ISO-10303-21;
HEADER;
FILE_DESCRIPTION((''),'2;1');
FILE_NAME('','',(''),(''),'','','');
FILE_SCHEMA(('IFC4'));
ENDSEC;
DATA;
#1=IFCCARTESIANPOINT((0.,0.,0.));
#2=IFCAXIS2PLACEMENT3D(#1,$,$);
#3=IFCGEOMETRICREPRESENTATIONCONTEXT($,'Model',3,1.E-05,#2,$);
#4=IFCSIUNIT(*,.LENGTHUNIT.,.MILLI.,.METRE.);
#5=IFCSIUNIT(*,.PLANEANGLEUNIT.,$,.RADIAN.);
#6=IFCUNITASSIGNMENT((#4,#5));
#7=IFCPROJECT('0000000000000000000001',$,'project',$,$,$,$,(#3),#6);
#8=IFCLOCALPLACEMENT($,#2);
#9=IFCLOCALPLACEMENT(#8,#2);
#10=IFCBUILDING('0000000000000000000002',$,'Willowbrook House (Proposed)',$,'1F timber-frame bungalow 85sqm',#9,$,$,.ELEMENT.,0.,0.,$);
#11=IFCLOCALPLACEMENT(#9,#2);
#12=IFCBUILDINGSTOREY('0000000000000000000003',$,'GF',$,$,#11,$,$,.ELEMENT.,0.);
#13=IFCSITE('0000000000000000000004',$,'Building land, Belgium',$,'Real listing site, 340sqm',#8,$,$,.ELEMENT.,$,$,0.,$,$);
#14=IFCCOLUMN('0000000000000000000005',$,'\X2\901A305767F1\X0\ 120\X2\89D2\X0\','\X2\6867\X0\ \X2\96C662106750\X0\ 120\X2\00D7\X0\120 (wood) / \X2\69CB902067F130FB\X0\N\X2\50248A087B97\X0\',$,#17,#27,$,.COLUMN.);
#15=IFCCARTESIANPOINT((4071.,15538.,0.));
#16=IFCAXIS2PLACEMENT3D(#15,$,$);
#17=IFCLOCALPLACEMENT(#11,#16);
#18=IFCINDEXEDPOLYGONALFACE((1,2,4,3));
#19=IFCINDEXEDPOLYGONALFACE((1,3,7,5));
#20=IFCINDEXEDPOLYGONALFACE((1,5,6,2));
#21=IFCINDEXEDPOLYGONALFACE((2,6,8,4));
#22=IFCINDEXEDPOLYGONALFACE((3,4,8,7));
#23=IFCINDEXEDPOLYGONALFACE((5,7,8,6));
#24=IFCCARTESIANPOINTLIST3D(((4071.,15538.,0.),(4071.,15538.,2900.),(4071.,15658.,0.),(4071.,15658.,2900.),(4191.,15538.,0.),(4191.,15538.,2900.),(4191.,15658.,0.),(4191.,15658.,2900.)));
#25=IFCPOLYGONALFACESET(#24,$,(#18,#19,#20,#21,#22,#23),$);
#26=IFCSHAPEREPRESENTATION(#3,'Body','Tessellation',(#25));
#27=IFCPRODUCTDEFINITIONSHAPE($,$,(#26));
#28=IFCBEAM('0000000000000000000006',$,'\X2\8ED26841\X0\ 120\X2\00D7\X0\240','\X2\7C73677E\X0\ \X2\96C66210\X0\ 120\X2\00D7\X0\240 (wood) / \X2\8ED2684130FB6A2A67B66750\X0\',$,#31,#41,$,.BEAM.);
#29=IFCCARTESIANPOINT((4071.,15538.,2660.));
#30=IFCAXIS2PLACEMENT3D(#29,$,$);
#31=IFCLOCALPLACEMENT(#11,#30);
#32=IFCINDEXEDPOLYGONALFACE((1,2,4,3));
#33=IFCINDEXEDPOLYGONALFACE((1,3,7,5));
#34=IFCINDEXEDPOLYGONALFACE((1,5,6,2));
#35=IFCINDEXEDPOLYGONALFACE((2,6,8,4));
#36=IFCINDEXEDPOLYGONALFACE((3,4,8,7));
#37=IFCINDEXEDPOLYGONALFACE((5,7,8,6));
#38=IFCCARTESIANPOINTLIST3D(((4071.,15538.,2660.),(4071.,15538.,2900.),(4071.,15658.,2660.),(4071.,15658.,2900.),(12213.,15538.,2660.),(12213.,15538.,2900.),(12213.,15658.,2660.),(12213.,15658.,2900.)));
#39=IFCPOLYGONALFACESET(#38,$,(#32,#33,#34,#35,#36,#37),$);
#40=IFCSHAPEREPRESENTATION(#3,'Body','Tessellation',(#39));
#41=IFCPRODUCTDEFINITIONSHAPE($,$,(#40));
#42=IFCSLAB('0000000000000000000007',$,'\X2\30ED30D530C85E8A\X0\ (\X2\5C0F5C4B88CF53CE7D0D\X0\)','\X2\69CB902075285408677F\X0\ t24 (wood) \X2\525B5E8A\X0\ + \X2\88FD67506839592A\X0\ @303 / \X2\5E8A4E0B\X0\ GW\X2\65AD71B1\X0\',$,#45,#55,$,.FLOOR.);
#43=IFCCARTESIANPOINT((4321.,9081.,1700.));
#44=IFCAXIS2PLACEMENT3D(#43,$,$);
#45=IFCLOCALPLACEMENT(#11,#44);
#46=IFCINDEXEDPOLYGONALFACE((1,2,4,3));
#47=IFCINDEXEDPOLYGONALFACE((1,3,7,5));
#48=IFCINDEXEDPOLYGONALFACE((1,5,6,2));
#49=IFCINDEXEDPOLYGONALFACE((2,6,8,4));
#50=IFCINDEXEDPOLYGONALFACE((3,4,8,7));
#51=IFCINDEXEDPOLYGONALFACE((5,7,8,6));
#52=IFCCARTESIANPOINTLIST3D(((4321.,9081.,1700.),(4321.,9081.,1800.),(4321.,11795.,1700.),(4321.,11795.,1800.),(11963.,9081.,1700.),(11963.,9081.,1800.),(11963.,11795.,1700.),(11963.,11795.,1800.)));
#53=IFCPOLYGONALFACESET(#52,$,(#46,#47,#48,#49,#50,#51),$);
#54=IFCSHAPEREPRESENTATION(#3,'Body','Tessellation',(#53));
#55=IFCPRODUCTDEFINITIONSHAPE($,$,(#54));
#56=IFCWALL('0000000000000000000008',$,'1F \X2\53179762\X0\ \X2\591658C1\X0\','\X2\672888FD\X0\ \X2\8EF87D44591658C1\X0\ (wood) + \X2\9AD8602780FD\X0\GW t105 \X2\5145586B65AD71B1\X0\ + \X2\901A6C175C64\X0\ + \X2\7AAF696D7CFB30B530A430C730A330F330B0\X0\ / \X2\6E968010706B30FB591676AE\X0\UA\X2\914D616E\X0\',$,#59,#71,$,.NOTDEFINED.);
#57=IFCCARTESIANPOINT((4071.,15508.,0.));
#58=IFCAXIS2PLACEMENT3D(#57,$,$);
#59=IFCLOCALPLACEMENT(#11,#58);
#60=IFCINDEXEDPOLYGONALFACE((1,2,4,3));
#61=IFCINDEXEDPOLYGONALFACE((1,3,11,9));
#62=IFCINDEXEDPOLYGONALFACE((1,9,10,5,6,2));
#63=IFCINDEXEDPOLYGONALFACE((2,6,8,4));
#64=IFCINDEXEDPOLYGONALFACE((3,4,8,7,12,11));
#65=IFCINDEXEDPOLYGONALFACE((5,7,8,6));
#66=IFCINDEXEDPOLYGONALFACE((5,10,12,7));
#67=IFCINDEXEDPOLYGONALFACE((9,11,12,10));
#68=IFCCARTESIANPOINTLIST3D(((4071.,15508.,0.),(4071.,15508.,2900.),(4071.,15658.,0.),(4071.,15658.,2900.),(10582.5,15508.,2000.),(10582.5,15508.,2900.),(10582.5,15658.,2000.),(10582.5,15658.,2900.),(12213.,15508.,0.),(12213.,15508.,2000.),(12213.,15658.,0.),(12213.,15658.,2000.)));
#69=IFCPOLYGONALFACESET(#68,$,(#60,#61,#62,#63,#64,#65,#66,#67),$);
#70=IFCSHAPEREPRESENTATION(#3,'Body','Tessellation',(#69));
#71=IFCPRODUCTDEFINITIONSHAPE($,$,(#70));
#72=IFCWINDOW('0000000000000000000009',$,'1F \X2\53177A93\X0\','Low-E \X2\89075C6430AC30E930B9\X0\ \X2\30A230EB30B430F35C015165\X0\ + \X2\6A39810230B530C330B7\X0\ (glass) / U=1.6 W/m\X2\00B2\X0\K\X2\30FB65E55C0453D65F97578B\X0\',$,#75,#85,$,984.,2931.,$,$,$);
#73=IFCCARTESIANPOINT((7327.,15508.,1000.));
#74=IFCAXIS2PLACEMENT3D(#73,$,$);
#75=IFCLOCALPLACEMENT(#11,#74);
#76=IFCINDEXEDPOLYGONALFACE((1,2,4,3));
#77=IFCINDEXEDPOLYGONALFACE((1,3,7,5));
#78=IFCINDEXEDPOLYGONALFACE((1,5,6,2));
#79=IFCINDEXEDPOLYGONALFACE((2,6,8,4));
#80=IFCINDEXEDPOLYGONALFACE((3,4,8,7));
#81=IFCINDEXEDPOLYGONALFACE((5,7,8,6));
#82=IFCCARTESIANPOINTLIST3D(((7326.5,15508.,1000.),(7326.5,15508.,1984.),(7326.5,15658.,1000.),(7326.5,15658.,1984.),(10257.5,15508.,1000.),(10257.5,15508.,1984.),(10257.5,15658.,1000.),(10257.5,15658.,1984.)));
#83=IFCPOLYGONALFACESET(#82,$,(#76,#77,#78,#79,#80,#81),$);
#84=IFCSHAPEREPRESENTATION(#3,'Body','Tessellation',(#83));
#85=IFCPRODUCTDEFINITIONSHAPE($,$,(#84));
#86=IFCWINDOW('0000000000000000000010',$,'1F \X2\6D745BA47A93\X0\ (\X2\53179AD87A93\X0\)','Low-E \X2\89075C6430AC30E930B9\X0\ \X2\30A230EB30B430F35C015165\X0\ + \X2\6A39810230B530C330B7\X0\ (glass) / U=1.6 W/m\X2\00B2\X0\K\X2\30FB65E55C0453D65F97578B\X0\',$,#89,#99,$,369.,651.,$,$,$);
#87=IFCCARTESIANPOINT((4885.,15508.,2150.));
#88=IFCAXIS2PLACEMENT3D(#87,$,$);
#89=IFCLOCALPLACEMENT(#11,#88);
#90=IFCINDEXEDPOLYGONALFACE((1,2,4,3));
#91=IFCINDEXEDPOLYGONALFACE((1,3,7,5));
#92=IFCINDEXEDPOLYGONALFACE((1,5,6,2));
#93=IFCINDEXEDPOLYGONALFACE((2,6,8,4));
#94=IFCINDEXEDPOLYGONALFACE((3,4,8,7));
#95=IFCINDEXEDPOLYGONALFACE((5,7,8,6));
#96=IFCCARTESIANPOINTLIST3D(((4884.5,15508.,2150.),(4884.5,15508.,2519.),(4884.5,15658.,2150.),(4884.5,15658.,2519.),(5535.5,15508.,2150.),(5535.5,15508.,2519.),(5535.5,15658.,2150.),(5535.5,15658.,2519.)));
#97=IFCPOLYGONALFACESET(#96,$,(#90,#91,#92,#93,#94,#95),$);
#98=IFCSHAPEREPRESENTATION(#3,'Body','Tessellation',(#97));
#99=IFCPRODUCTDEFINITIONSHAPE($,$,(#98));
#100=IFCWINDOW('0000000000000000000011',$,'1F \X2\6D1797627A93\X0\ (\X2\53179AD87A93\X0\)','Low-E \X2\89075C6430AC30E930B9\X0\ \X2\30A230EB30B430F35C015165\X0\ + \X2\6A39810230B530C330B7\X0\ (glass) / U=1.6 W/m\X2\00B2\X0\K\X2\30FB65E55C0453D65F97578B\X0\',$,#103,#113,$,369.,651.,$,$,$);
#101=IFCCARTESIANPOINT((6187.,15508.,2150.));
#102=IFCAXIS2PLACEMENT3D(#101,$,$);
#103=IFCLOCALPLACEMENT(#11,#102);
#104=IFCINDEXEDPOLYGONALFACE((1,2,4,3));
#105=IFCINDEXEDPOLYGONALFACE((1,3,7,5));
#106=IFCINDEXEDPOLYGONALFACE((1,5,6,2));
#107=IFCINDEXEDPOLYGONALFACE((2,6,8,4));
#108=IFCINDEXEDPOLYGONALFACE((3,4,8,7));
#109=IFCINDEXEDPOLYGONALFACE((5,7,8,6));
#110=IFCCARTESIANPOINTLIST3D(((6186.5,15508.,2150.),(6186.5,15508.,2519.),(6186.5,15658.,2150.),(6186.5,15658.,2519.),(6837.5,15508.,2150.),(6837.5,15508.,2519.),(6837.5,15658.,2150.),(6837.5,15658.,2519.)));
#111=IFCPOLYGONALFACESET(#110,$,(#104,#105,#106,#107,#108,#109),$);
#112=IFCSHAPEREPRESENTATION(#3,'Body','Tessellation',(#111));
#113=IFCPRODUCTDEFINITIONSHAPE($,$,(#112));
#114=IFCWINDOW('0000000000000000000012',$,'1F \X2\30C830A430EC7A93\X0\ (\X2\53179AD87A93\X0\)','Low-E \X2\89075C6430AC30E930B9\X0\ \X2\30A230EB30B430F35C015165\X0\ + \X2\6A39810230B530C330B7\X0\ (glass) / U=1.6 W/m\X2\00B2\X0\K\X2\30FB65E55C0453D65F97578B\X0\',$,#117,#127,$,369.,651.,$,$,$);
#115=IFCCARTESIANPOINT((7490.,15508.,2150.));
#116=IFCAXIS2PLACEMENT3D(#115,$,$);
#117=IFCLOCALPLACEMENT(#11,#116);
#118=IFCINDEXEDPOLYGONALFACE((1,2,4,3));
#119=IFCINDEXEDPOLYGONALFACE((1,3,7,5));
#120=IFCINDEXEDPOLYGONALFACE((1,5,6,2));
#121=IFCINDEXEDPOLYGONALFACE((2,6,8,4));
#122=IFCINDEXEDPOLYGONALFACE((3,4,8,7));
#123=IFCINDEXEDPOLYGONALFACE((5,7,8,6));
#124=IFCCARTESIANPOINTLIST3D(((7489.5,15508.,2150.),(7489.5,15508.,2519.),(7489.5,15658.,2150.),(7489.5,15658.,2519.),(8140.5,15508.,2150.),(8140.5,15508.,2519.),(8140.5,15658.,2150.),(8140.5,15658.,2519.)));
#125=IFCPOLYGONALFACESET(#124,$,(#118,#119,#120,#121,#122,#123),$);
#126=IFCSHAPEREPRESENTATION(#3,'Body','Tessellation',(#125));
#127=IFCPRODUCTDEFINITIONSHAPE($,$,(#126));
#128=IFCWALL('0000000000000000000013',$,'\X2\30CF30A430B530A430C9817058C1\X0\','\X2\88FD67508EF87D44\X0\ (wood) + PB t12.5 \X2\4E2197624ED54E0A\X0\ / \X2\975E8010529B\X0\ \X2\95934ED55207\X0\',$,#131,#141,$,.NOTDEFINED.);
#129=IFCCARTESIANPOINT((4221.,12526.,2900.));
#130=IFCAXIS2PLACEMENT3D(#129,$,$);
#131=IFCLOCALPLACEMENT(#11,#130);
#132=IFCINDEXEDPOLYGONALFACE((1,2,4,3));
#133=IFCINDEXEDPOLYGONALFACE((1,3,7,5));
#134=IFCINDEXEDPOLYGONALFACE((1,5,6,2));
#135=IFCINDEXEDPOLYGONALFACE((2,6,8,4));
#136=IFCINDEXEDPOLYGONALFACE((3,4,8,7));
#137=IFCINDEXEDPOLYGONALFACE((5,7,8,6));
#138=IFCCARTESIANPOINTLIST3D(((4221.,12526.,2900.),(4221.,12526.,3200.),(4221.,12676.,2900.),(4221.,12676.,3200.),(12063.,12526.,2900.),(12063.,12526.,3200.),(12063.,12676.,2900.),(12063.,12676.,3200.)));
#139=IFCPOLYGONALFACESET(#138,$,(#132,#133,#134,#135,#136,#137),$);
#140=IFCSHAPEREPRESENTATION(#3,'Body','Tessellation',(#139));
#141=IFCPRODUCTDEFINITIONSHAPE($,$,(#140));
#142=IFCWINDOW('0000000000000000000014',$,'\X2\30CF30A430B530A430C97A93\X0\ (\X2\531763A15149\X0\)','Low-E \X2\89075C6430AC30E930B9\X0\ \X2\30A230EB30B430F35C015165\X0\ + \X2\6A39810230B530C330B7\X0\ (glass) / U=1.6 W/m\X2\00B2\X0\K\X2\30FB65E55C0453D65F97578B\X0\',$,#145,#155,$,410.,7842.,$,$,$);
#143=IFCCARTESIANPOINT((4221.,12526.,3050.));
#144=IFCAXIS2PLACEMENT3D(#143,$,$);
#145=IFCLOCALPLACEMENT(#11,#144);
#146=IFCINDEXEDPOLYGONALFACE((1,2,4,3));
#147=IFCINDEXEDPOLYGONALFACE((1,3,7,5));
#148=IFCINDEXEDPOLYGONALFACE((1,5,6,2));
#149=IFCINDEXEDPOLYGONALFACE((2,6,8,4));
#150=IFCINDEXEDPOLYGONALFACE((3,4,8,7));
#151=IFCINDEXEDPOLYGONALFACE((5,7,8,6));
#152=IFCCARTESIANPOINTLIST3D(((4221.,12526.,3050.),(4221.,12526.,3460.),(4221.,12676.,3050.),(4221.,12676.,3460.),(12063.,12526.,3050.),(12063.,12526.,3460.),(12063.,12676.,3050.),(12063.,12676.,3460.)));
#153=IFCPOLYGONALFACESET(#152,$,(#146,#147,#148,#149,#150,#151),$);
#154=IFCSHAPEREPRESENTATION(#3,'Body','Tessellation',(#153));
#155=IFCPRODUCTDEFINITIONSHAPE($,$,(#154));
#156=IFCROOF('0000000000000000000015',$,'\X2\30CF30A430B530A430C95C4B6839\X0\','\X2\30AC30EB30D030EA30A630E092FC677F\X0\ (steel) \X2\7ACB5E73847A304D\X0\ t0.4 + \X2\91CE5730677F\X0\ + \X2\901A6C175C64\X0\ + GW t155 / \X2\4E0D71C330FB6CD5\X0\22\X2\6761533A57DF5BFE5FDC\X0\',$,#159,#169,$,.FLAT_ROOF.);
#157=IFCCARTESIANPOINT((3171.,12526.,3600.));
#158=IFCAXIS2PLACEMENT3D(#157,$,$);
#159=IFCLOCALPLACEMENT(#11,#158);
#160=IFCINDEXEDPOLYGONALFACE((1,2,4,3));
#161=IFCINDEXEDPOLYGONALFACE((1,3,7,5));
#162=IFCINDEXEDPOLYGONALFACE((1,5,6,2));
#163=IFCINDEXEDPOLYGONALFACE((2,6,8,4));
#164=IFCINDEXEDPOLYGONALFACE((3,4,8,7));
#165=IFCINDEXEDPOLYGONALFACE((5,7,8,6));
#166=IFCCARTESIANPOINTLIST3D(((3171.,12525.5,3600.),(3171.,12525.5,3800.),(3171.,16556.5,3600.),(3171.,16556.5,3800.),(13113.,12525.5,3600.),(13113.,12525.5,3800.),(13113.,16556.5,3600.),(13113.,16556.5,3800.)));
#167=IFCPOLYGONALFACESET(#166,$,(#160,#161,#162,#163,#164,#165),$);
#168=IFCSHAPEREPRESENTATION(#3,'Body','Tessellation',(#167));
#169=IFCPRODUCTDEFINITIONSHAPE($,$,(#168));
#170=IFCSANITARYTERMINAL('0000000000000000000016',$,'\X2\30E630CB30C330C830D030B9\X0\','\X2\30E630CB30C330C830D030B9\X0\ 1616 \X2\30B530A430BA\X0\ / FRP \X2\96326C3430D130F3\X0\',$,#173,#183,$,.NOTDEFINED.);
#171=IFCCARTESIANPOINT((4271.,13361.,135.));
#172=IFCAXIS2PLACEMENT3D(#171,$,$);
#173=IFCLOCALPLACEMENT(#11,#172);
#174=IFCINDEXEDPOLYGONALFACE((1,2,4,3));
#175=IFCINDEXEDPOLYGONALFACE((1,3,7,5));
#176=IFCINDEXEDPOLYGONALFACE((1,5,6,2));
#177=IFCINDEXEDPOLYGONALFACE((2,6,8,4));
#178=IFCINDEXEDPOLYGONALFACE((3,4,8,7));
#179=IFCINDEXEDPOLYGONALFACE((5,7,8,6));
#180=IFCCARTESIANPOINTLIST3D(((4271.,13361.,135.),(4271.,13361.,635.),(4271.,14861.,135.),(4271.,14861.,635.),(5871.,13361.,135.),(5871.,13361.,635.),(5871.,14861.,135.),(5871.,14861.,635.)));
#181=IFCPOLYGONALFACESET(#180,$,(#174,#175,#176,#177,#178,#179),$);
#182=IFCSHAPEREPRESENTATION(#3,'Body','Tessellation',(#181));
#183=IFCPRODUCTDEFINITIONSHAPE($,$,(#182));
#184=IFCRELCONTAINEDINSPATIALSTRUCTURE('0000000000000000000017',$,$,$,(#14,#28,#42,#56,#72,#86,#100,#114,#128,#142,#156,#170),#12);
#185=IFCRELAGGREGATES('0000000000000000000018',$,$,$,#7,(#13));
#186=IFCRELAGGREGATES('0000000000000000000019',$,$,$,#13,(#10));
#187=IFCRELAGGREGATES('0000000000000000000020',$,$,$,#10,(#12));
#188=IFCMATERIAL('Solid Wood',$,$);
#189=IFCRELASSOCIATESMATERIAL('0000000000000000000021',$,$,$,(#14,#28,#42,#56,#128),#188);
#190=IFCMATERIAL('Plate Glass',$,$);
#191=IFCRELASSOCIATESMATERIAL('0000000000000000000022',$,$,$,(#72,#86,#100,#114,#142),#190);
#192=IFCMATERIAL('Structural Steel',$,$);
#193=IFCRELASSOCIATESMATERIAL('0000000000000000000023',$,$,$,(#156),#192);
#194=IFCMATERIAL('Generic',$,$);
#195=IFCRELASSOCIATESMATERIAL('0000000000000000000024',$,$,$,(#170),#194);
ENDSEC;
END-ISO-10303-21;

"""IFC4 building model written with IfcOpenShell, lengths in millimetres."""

from ifc_helpers import new_model, si_unit, frame, frame_2d, origin, place, context, project, spatial, rectangle, extrude, material, element, fill, save


model = new_model("IFC4")

# Units and contexts
model_context = context("Model", 3, precision=1e-05, world=origin())
ifc_project = project(units=[si_unit("LENGTHUNIT", "METRE", prefix="MILLI"), si_unit("PLANEANGLEUNIT", "RADIAN")], contexts=[model_context])

# Site, building, storey
site_placement = place(None, origin())
site = spatial("IfcSite", under=ifc_project, at=site_placement, Name="Building land, Belgium", ObjectType="Real listing site, 340sqm", CompositionType="ELEMENT", RefElevation=0.0)
building_placement = place(site_placement, origin())
building = spatial("IfcBuilding", under=site, at=building_placement, Name="Willowbrook House (Proposed)", ObjectType="1F timber-frame bungalow 85sqm", CompositionType="ELEMENT", ElevationOfRefHeight=0.0, ElevationOfTerrain=0.0)
storey_placement = place(building_placement, origin())
storey = spatial("IfcBuildingStorey", under=building, at=storey_placement, Name="GF", CompositionType="ELEMENT", Elevation=0.0)

# Column
ifc_material_1 = material(Name="Solid Wood")
column_1_placement = place(storey_placement, frame((4071.0, 15538.0, 0.0)))
element("IfcColumn", 1, at=column_1_placement, inside=storey, material=ifc_material_1, Name="通し柱 120角", Description="桧 集成材 120×120 (wood) / 構造柱・N値計算", PredefinedType="COLUMN", context=model_context, shape_type="SweptSolid", body=[
    extrude(rectangle(XDim=120.0, YDim=120.0, at=frame_2d((60.0, 60.0))), frame((4071.0, 15538.0, 0.0)), (0.0, 0.0, 1.0), 2900.0),
])

# Beam
beam_1_placement = place(storey_placement, frame((4071.0, 15538.0, 2660.0)))
element("IfcBeam", 2, at=beam_1_placement, inside=storey, material=ifc_material_1, Name="軒桁 120×240", Description="米松 集成 120×240 (wood) / 軒桁・横架材", PredefinedType="BEAM", context=model_context, shape_type="SweptSolid", body=[
    extrude(rectangle(XDim=8142.0, YDim=120.0, at=frame_2d((4071.0, 60.0))), frame((4071.0, 15538.0, 2660.0)), (0.0, 0.0, 1.0), 240.0),
])

# Slab
slab_placement = place(storey_placement, frame((4321.0, 9081.0, 1700.0)))
element("IfcSlab", 3, at=slab_placement, inside=storey, material=ifc_material_1, Name="ロフト床 (小屋裏収納)", Description="構造用合板 t24 (wood) 剛床 + 製材根太 @303 / 床下 GW断熱", PredefinedType="FLOOR", context=model_context, shape_type="SweptSolid", body=[
    extrude(rectangle(XDim=7642.0, YDim=2714.0, at=frame_2d((3821.0, 1357.0))), frame((4321.0, 9081.0, 1700.0)), (0.0, 0.0, 1.0), 100.0),
])

# Wall, openings, windows
wall_1_placement = place(storey_placement, frame((4071.0, 15508.0, 0.0)))
wall_1 = element("IfcWall", 4, at=wall_1_placement, inside=storey, material=ifc_material_1, Name="1F 北面 外壁", Description="木製 軸組外壁 (wood) + 高性能GW t105 充填断熱 + 通気層 + 窯業系サイディング / 準耐火・外皮UA配慮", PredefinedType="NOTDEFINED", context=model_context, shape_type="SweptSolid", body=[
    extrude(rectangle(XDim=8142.0, YDim=150.0, at=frame_2d((4071.0, 75.0))), frame((4071.0, 15508.0, 0.0)), (0.0, 0.0, 1.0), 2900.0),
])
opening_1_placement = place(storey_placement, frame((7327.0, 15508.0, 1000.0)))
opening_1 = element("IfcOpeningElement", 5, at=opening_1_placement, cuts=wall_1, PredefinedType="NOTDEFINED", context=model_context, shape_type="SweptSolid", body=[
    extrude(rectangle(XDim=2931.0, YDim=150.0, at=frame_2d((1465.0, 75.0))), frame((7327.0, 15508.0, 1000.0)), (0.0, 0.0, 1.0), 984.0),
])
opening_2_placement = place(storey_placement, frame((4885.0, 15508.0, 2150.0)))
opening_2 = element("IfcOpeningElement", 6, at=opening_2_placement, cuts=wall_1, PredefinedType="NOTDEFINED", context=model_context, shape_type="SweptSolid", body=[
    extrude(rectangle(XDim=651.0, YDim=150.0, at=frame_2d((325.0, 75.0))), frame((4885.0, 15508.0, 2150.0)), (0.0, 0.0, 1.0), 369.0),
])
opening_3_placement = place(storey_placement, frame((6187.0, 15508.0, 2150.0)))
opening_3 = element("IfcOpeningElement", 7, at=opening_3_placement, cuts=wall_1, PredefinedType="NOTDEFINED", context=model_context, shape_type="SweptSolid", body=[
    extrude(rectangle(XDim=651.0, YDim=150.0, at=frame_2d((325.0, 75.0))), frame((6187.0, 15508.0, 2150.0)), (0.0, 0.0, 1.0), 369.0),
])
opening_4_placement = place(storey_placement, frame((7490.0, 15508.0, 2150.0)))
opening_4 = element("IfcOpeningElement", 8, at=opening_4_placement, cuts=wall_1, PredefinedType="NOTDEFINED", context=model_context, shape_type="SweptSolid", body=[
    extrude(rectangle(XDim=651.0, YDim=150.0, at=frame_2d((325.0, 75.0))), frame((7490.0, 15508.0, 2150.0)), (0.0, 0.0, 1.0), 369.0),
])
ifc_material_2 = material(Name="Plate Glass")
window_1_placement = place(storey_placement, frame((7327.0, 15508.0, 1000.0)))
window_1 = element("IfcWindow", 9, at=window_1_placement, inside=storey, material=ifc_material_2, Name="1F 北窓", Description="Low-E 複層ガラス アルゴン封入 + 樹脂サッシ (glass) / U=1.6 W/m²K・日射取得型", OverallHeight=984.0, OverallWidth=2931.0, context=model_context, shape_type="SweptSolid", body=[
    extrude(rectangle(XDim=2931.0, YDim=150.0, at=frame_2d((1465.0, 75.0))), frame((7327.0, 15508.0, 1000.0)), (0.0, 0.0, 1.0), 984.0),
])
fill(opening_1, window_1)
window_2_placement = place(storey_placement, frame((4885.0, 15508.0, 2150.0)))
window_2 = element("IfcWindow", 10, at=window_2_placement, inside=storey, material=ifc_material_2, Name="1F 浴室窓 (北高窓)", Description="Low-E 複層ガラス アルゴン封入 + 樹脂サッシ (glass) / U=1.6 W/m²K・日射取得型", OverallHeight=369.0, OverallWidth=651.0, context=model_context, shape_type="SweptSolid", body=[
    extrude(rectangle(XDim=651.0, YDim=150.0, at=frame_2d((325.0, 75.0))), frame((4885.0, 15508.0, 2150.0)), (0.0, 0.0, 1.0), 369.0),
])
fill(opening_2, window_2)
window_3_placement = place(storey_placement, frame((6187.0, 15508.0, 2150.0)))
window_3 = element("IfcWindow", 11, at=window_3_placement, inside=storey, material=ifc_material_2, Name="1F 洗面窓 (北高窓)", Description="Low-E 複層ガラス アルゴン封入 + 樹脂サッシ (glass) / U=1.6 W/m²K・日射取得型", OverallHeight=369.0, OverallWidth=651.0, context=model_context, shape_type="SweptSolid", body=[
    extrude(rectangle(XDim=651.0, YDim=150.0, at=frame_2d((325.0, 75.0))), frame((6187.0, 15508.0, 2150.0)), (0.0, 0.0, 1.0), 369.0),
])
fill(opening_3, window_3)
window_4_placement = place(storey_placement, frame((7490.0, 15508.0, 2150.0)))
window_4 = element("IfcWindow", 12, at=window_4_placement, inside=storey, material=ifc_material_2, Name="1F トイレ窓 (北高窓)", Description="Low-E 複層ガラス アルゴン封入 + 樹脂サッシ (glass) / U=1.6 W/m²K・日射取得型", OverallHeight=369.0, OverallWidth=651.0, context=model_context, shape_type="SweptSolid", body=[
    extrude(rectangle(XDim=651.0, YDim=150.0, at=frame_2d((325.0, 75.0))), frame((7490.0, 15508.0, 2150.0)), (0.0, 0.0, 1.0), 369.0),
])
fill(opening_4, window_4)

# Wall, opening, window
wall_2_placement = place(storey_placement, frame((4221.0, 12526.0, 2900.0)))
wall_2 = element("IfcWall", 13, at=wall_2_placement, inside=storey, material=ifc_material_1, Name="ハイサイド腰壁", Description="製材軸組 (wood) + PB t12.5 両面仕上 / 非耐力 間仕切", PredefinedType="NOTDEFINED", context=model_context, shape_type="SweptSolid", body=[
    extrude(rectangle(XDim=7842.0, YDim=150.0, at=frame_2d((3921.0, 75.0))), frame((4221.0, 12526.0, 2900.0)), (0.0, 0.0, 1.0), 700.0),
])
opening_5_placement = place(storey_placement, frame((4221.0, 12526.0, 3050.0)))
opening_5 = element("IfcOpeningElement", 14, at=opening_5_placement, cuts=wall_2, PredefinedType="NOTDEFINED", context=model_context, shape_type="SweptSolid", body=[
    extrude(rectangle(XDim=7842.0, YDim=150.0, at=frame_2d((3921.0, 75.0))), frame((4221.0, 12526.0, 3050.0)), (0.0, 0.0, 1.0), 410.0),
])
window_5_placement = place(storey_placement, frame((4221.0, 12526.0, 3050.0)))
window_5 = element("IfcWindow", 15, at=window_5_placement, inside=storey, material=ifc_material_2, Name="ハイサイド窓 (北採光)", Description="Low-E 複層ガラス アルゴン封入 + 樹脂サッシ (glass) / U=1.6 W/m²K・日射取得型", OverallHeight=410.0, OverallWidth=7842.0, context=model_context, shape_type="SweptSolid", body=[
    extrude(rectangle(XDim=7842.0, YDim=150.0, at=frame_2d((3921.0, 75.0))), frame((4221.0, 12526.0, 3050.0)), (0.0, 0.0, 1.0), 410.0),
])
fill(opening_5, window_5)

# Roof
ifc_material_3 = material(Name="Structural Steel")
roof_placement = place(storey_placement, frame((3171.0, 12526.0, 3600.0)))
element("IfcRoof", 16, at=roof_placement, inside=storey, material=ifc_material_3, Name="ハイサイド屋根", Description="ガルバリウム鋼板 (steel) 立平葺き t0.4 + 野地板 + 通気層 + GW t155 / 不燃・法22条区域対応", PredefinedType="FLAT_ROOF", context=model_context, shape_type="SweptSolid", body=[
    extrude(rectangle(XDim=9942.0, YDim=4031.0, at=frame_2d((4971.0, 2015.0))), frame((3171.0, 12526.0, 3600.0)), (0.0, 0.0, 1.0), 200.0),
])

# Sanitary terminal
ifc_material_4 = material(Name="Generic")
sanitary_terminal_placement = place(storey_placement, frame((4271.0, 13361.0, 135.0)))
element("IfcSanitaryTerminal", 17, at=sanitary_terminal_placement, inside=storey, material=ifc_material_4, Name="ユニットバス", Description="ユニットバス 1616 サイズ / FRP 防水パン", PredefinedType="NOTDEFINED", context=model_context, shape_type="SweptSolid", body=[
    extrude(rectangle(XDim=1600.0, YDim=1500.0, at=frame_2d((800.0, 750.0))), frame((4271.0, 13361.0, 135.0)), (0.0, 0.0, 1.0), 500.0),
])

save(model, "model.ifc")
